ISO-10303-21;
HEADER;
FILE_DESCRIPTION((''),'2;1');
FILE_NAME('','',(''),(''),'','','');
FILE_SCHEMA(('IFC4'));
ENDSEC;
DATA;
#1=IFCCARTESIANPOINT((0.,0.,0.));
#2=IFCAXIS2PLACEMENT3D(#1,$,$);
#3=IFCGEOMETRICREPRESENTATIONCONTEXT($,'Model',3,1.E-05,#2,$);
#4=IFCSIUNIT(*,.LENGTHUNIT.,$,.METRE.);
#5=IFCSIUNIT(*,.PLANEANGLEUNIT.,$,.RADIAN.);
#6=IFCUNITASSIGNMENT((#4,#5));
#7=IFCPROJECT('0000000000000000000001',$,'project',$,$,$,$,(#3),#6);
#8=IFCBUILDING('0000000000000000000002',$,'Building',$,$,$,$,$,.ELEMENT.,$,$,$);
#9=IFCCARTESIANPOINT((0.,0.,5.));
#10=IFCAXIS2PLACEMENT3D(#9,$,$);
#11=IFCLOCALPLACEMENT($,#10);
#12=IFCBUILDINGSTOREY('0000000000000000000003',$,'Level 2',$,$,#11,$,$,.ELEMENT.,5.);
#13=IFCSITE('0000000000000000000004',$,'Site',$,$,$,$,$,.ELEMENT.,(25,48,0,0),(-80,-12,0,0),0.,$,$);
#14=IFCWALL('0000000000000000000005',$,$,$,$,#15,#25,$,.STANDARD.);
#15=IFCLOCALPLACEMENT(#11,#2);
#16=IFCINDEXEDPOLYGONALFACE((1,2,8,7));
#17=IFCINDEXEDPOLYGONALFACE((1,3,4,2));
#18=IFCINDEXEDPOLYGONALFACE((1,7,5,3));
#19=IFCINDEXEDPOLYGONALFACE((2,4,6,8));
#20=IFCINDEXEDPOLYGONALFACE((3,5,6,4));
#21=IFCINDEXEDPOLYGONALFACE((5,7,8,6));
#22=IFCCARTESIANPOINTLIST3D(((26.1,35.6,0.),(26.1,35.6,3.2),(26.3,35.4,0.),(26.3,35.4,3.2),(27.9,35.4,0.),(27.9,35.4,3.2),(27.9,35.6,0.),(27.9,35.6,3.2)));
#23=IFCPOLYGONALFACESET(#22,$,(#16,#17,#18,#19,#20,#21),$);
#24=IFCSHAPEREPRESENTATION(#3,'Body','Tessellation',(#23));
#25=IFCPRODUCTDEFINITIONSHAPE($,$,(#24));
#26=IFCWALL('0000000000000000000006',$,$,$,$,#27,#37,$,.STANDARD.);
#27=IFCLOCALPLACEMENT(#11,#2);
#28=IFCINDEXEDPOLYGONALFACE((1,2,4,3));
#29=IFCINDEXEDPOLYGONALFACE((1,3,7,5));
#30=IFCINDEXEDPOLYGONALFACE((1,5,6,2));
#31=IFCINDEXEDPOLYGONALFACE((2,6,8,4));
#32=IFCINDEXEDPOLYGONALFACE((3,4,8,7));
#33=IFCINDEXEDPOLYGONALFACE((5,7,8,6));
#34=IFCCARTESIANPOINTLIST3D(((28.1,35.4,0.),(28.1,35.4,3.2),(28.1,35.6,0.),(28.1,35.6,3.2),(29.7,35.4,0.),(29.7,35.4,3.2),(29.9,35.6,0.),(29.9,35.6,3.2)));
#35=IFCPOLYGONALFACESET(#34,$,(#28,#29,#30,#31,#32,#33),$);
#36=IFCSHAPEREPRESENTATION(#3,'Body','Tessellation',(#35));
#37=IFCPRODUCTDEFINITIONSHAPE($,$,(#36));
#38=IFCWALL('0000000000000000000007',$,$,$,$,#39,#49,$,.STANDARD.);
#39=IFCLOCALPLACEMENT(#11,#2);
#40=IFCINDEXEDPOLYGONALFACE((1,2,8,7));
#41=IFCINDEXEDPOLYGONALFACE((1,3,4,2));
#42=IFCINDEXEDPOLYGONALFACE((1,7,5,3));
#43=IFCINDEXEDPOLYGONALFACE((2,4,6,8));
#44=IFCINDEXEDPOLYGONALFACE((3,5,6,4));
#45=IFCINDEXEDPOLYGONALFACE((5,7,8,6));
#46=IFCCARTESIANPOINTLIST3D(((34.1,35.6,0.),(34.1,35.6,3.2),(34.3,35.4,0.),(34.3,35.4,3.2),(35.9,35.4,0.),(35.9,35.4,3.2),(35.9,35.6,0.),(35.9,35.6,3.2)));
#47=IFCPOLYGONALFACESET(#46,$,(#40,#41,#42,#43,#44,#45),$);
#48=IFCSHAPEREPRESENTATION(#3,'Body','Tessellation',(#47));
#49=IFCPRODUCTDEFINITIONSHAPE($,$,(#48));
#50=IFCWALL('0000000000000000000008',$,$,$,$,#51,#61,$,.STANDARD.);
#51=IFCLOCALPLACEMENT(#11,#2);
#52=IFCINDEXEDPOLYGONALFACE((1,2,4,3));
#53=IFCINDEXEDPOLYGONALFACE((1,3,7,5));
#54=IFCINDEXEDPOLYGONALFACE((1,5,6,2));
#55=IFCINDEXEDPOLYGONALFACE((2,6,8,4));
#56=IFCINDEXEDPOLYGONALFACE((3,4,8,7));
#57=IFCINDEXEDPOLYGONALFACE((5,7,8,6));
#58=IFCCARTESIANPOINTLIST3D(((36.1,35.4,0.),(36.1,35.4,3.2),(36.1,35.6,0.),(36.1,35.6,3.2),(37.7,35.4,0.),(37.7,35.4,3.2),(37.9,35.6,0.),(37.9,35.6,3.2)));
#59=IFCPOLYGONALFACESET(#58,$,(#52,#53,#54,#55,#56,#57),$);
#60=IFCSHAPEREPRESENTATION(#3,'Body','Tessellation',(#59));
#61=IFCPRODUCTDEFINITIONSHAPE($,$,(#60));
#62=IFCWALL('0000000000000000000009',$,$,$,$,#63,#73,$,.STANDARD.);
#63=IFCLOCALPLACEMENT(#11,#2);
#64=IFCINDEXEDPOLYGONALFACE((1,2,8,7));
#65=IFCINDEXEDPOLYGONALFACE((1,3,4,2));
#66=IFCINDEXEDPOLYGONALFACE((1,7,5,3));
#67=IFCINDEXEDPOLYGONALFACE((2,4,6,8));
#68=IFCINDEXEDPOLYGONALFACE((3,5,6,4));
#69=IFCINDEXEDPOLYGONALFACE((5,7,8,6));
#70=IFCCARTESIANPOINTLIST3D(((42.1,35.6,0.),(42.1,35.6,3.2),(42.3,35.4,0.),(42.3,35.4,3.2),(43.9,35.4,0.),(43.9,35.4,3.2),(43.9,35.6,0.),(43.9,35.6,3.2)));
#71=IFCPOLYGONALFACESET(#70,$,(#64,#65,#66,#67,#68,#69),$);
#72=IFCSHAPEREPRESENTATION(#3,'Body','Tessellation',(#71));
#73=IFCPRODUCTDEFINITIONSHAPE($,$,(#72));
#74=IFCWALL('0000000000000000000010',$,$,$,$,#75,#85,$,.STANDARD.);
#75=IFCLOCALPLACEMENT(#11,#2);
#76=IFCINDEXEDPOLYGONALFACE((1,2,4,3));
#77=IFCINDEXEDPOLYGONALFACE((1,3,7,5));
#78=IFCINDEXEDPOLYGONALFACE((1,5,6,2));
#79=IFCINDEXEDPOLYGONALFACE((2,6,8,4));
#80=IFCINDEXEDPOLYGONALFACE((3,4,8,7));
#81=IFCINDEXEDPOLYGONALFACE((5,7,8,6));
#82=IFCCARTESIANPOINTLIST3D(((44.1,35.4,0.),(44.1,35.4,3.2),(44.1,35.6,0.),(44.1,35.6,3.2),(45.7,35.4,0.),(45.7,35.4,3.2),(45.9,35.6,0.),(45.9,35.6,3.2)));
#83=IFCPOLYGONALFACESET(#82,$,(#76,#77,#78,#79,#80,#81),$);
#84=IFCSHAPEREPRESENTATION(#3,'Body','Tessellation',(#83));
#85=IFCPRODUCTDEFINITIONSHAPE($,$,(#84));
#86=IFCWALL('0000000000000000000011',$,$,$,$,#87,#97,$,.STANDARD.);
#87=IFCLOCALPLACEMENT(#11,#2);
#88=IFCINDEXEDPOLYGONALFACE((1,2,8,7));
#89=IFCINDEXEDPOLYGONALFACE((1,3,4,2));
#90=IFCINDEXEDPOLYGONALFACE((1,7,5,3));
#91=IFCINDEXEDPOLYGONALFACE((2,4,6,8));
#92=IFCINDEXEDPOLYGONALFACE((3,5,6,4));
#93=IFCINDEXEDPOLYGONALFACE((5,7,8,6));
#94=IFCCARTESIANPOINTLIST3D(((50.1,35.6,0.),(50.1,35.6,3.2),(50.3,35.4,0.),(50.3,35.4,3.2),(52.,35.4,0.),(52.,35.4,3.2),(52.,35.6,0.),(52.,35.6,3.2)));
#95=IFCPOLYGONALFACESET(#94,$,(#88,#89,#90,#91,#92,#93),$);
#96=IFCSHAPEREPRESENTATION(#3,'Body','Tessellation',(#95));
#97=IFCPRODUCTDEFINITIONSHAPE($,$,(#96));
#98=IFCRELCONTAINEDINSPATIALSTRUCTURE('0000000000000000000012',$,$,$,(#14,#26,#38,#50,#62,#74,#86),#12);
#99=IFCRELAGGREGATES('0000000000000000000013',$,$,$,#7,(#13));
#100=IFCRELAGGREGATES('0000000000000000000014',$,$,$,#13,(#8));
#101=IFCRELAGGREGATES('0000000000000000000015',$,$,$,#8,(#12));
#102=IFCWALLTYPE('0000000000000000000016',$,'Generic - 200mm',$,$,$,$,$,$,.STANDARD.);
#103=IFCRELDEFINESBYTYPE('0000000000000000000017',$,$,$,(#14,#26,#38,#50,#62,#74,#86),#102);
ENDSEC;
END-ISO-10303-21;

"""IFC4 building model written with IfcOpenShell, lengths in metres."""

from ifc_helpers import new_model, si_unit, frame, origin, place, context, project, spatial, polyline, outline, extrude, type_object, element, save


model = new_model("IFC4")

# Units and contexts
model_context = context("Model", 3, precision=1e-05, world=origin())
ifc_project = project(units=[si_unit("LENGTHUNIT", "METRE"), si_unit("PLANEANGLEUNIT", "RADIAN")], contexts=[model_context])

# Site, building, storey
site = spatial("IfcSite", under=ifc_project, Name="Site", CompositionType="ELEMENT", RefLatitude=(25, 48, 0, 0), RefLongitude=(-80, -12, 0, 0), RefElevation=0.0)
building = spatial("IfcBuilding", under=site, Name="Building", CompositionType="ELEMENT")
storey_placement = place(None, frame((0.0, 0.0, 5.0)))
storey = spatial("IfcBuildingStorey", under=building, at=storey_placement, Name="Level 2", CompositionType="ELEMENT", Elevation=5.0)

# Shared definitions
wall_type = type_object("IfcWallType", Name="Generic - 200mm", PredefinedType="STANDARD")

# Walls
wall_1_placement = place(None, frame((26.2, 35.5, 5.0), z_axis=(0.0, 0.0, 1.0), x_axis=(1.0, 0.0, 0.0)))
element("IfcWall", 1, at=wall_1_placement, inside=storey, type_object=wall_type, PredefinedType="STANDARD", context=model_context, shape_type="SweptSolid", body=[
    extrude(outline(polyline([(0.1, -0.1), (1.7, -0.1), (1.7, 0.1), (-0.1, 0.1), (0.1, -0.1)])), origin(), (0.0, 0.0, 1.0), 3.2),
])
wall_2_placement = place(None, frame((29.8, 35.5, 5.0), z_axis=(0.0, 0.0, 1.0), x_axis=(-1.0, 0.0, 0.0)))
element("IfcWall", 2, at=wall_2_placement, inside=storey, type_object=wall_type, PredefinedType="STANDARD", context=model_context, shape_type="SweptSolid", body=[
    extrude(outline(polyline([(-0.1, -0.1), (1.7, -0.1), (1.7, 0.1), (0.1, 0.1), (-0.1, -0.1)])), origin(), (0.0, 0.0, 1.0), 3.2),
])
wall_3_placement = place(None, frame((34.2, 35.5, 5.0), z_axis=(0.0, 0.0, 1.0), x_axis=(1.0, 0.0, 0.0)))
element("IfcWall", 3, at=wall_3_placement, inside=storey, type_object=wall_type, PredefinedType="STANDARD", context=model_context, shape_type="SweptSolid", body=[
    extrude(outline(polyline([(0.1, -0.1), (1.7, -0.1), (1.7, 0.1), (-0.1, 0.1), (0.1, -0.1)])), origin(), (0.0, 0.0, 1.0), 3.2),
])
wall_4_placement = place(None, frame((37.8, 35.5, 5.0), z_axis=(0.0, 0.0, 1.0), x_axis=(-1.0, 0.0, 0.0)))
element("IfcWall", 4, at=wall_4_placement, inside=storey, type_object=wall_type, PredefinedType="STANDARD", context=model_context, shape_type="SweptSolid", body=[
    extrude(outline(polyline([(-0.1, -0.1), (1.7, -0.1), (1.7, 0.1), (0.1, 0.1), (-0.1, -0.1)])), origin(), (0.0, 0.0, 1.0), 3.2),
])
wall_5_placement = place(None, frame((42.2, 35.5, 5.0), z_axis=(0.0, 0.0, 1.0), x_axis=(1.0, 0.0, 0.0)))
element("IfcWall", 5, at=wall_5_placement, inside=storey, type_object=wall_type, PredefinedType="STANDARD", context=model_context, shape_type="SweptSolid", body=[
    extrude(outline(polyline([(0.1, -0.1), (1.7, -0.1), (1.7, 0.1), (-0.1, 0.1), (0.1, -0.1)])), origin(), (0.0, 0.0, 1.0), 3.2),
])
wall_6_placement = place(None, frame((45.8, 35.5, 5.0), z_axis=(0.0, 0.0, 1.0), x_axis=(-1.0, 0.0, 0.0)))
element("IfcWall", 6, at=wall_6_placement, inside=storey, type_object=wall_type, PredefinedType="STANDARD", context=model_context, shape_type="SweptSolid", body=[
    extrude(outline(polyline([(-0.1, -0.1), (1.7, -0.1), (1.7, 0.1), (0.1, 0.1), (-0.1, -0.1)])), origin(), (0.0, 0.0, 1.0), 3.2),
])
wall_7_placement = place(None, frame((50.2, 35.5, 5.0), z_axis=(0.0, 0.0, 1.0), x_axis=(1.0, 0.0, 0.0)))
element("IfcWall", 7, at=wall_7_placement, inside=storey, type_object=wall_type, PredefinedType="STANDARD", context=model_context, shape_type="SweptSolid", body=[
    extrude(outline(polyline([(0.1, -0.1), (1.8, -0.1), (1.8, 0.1), (-0.1, 0.1), (0.1, -0.1)])), origin(), (0.0, 0.0, 1.0), 3.2),
])

save(model, "model.ifc")
